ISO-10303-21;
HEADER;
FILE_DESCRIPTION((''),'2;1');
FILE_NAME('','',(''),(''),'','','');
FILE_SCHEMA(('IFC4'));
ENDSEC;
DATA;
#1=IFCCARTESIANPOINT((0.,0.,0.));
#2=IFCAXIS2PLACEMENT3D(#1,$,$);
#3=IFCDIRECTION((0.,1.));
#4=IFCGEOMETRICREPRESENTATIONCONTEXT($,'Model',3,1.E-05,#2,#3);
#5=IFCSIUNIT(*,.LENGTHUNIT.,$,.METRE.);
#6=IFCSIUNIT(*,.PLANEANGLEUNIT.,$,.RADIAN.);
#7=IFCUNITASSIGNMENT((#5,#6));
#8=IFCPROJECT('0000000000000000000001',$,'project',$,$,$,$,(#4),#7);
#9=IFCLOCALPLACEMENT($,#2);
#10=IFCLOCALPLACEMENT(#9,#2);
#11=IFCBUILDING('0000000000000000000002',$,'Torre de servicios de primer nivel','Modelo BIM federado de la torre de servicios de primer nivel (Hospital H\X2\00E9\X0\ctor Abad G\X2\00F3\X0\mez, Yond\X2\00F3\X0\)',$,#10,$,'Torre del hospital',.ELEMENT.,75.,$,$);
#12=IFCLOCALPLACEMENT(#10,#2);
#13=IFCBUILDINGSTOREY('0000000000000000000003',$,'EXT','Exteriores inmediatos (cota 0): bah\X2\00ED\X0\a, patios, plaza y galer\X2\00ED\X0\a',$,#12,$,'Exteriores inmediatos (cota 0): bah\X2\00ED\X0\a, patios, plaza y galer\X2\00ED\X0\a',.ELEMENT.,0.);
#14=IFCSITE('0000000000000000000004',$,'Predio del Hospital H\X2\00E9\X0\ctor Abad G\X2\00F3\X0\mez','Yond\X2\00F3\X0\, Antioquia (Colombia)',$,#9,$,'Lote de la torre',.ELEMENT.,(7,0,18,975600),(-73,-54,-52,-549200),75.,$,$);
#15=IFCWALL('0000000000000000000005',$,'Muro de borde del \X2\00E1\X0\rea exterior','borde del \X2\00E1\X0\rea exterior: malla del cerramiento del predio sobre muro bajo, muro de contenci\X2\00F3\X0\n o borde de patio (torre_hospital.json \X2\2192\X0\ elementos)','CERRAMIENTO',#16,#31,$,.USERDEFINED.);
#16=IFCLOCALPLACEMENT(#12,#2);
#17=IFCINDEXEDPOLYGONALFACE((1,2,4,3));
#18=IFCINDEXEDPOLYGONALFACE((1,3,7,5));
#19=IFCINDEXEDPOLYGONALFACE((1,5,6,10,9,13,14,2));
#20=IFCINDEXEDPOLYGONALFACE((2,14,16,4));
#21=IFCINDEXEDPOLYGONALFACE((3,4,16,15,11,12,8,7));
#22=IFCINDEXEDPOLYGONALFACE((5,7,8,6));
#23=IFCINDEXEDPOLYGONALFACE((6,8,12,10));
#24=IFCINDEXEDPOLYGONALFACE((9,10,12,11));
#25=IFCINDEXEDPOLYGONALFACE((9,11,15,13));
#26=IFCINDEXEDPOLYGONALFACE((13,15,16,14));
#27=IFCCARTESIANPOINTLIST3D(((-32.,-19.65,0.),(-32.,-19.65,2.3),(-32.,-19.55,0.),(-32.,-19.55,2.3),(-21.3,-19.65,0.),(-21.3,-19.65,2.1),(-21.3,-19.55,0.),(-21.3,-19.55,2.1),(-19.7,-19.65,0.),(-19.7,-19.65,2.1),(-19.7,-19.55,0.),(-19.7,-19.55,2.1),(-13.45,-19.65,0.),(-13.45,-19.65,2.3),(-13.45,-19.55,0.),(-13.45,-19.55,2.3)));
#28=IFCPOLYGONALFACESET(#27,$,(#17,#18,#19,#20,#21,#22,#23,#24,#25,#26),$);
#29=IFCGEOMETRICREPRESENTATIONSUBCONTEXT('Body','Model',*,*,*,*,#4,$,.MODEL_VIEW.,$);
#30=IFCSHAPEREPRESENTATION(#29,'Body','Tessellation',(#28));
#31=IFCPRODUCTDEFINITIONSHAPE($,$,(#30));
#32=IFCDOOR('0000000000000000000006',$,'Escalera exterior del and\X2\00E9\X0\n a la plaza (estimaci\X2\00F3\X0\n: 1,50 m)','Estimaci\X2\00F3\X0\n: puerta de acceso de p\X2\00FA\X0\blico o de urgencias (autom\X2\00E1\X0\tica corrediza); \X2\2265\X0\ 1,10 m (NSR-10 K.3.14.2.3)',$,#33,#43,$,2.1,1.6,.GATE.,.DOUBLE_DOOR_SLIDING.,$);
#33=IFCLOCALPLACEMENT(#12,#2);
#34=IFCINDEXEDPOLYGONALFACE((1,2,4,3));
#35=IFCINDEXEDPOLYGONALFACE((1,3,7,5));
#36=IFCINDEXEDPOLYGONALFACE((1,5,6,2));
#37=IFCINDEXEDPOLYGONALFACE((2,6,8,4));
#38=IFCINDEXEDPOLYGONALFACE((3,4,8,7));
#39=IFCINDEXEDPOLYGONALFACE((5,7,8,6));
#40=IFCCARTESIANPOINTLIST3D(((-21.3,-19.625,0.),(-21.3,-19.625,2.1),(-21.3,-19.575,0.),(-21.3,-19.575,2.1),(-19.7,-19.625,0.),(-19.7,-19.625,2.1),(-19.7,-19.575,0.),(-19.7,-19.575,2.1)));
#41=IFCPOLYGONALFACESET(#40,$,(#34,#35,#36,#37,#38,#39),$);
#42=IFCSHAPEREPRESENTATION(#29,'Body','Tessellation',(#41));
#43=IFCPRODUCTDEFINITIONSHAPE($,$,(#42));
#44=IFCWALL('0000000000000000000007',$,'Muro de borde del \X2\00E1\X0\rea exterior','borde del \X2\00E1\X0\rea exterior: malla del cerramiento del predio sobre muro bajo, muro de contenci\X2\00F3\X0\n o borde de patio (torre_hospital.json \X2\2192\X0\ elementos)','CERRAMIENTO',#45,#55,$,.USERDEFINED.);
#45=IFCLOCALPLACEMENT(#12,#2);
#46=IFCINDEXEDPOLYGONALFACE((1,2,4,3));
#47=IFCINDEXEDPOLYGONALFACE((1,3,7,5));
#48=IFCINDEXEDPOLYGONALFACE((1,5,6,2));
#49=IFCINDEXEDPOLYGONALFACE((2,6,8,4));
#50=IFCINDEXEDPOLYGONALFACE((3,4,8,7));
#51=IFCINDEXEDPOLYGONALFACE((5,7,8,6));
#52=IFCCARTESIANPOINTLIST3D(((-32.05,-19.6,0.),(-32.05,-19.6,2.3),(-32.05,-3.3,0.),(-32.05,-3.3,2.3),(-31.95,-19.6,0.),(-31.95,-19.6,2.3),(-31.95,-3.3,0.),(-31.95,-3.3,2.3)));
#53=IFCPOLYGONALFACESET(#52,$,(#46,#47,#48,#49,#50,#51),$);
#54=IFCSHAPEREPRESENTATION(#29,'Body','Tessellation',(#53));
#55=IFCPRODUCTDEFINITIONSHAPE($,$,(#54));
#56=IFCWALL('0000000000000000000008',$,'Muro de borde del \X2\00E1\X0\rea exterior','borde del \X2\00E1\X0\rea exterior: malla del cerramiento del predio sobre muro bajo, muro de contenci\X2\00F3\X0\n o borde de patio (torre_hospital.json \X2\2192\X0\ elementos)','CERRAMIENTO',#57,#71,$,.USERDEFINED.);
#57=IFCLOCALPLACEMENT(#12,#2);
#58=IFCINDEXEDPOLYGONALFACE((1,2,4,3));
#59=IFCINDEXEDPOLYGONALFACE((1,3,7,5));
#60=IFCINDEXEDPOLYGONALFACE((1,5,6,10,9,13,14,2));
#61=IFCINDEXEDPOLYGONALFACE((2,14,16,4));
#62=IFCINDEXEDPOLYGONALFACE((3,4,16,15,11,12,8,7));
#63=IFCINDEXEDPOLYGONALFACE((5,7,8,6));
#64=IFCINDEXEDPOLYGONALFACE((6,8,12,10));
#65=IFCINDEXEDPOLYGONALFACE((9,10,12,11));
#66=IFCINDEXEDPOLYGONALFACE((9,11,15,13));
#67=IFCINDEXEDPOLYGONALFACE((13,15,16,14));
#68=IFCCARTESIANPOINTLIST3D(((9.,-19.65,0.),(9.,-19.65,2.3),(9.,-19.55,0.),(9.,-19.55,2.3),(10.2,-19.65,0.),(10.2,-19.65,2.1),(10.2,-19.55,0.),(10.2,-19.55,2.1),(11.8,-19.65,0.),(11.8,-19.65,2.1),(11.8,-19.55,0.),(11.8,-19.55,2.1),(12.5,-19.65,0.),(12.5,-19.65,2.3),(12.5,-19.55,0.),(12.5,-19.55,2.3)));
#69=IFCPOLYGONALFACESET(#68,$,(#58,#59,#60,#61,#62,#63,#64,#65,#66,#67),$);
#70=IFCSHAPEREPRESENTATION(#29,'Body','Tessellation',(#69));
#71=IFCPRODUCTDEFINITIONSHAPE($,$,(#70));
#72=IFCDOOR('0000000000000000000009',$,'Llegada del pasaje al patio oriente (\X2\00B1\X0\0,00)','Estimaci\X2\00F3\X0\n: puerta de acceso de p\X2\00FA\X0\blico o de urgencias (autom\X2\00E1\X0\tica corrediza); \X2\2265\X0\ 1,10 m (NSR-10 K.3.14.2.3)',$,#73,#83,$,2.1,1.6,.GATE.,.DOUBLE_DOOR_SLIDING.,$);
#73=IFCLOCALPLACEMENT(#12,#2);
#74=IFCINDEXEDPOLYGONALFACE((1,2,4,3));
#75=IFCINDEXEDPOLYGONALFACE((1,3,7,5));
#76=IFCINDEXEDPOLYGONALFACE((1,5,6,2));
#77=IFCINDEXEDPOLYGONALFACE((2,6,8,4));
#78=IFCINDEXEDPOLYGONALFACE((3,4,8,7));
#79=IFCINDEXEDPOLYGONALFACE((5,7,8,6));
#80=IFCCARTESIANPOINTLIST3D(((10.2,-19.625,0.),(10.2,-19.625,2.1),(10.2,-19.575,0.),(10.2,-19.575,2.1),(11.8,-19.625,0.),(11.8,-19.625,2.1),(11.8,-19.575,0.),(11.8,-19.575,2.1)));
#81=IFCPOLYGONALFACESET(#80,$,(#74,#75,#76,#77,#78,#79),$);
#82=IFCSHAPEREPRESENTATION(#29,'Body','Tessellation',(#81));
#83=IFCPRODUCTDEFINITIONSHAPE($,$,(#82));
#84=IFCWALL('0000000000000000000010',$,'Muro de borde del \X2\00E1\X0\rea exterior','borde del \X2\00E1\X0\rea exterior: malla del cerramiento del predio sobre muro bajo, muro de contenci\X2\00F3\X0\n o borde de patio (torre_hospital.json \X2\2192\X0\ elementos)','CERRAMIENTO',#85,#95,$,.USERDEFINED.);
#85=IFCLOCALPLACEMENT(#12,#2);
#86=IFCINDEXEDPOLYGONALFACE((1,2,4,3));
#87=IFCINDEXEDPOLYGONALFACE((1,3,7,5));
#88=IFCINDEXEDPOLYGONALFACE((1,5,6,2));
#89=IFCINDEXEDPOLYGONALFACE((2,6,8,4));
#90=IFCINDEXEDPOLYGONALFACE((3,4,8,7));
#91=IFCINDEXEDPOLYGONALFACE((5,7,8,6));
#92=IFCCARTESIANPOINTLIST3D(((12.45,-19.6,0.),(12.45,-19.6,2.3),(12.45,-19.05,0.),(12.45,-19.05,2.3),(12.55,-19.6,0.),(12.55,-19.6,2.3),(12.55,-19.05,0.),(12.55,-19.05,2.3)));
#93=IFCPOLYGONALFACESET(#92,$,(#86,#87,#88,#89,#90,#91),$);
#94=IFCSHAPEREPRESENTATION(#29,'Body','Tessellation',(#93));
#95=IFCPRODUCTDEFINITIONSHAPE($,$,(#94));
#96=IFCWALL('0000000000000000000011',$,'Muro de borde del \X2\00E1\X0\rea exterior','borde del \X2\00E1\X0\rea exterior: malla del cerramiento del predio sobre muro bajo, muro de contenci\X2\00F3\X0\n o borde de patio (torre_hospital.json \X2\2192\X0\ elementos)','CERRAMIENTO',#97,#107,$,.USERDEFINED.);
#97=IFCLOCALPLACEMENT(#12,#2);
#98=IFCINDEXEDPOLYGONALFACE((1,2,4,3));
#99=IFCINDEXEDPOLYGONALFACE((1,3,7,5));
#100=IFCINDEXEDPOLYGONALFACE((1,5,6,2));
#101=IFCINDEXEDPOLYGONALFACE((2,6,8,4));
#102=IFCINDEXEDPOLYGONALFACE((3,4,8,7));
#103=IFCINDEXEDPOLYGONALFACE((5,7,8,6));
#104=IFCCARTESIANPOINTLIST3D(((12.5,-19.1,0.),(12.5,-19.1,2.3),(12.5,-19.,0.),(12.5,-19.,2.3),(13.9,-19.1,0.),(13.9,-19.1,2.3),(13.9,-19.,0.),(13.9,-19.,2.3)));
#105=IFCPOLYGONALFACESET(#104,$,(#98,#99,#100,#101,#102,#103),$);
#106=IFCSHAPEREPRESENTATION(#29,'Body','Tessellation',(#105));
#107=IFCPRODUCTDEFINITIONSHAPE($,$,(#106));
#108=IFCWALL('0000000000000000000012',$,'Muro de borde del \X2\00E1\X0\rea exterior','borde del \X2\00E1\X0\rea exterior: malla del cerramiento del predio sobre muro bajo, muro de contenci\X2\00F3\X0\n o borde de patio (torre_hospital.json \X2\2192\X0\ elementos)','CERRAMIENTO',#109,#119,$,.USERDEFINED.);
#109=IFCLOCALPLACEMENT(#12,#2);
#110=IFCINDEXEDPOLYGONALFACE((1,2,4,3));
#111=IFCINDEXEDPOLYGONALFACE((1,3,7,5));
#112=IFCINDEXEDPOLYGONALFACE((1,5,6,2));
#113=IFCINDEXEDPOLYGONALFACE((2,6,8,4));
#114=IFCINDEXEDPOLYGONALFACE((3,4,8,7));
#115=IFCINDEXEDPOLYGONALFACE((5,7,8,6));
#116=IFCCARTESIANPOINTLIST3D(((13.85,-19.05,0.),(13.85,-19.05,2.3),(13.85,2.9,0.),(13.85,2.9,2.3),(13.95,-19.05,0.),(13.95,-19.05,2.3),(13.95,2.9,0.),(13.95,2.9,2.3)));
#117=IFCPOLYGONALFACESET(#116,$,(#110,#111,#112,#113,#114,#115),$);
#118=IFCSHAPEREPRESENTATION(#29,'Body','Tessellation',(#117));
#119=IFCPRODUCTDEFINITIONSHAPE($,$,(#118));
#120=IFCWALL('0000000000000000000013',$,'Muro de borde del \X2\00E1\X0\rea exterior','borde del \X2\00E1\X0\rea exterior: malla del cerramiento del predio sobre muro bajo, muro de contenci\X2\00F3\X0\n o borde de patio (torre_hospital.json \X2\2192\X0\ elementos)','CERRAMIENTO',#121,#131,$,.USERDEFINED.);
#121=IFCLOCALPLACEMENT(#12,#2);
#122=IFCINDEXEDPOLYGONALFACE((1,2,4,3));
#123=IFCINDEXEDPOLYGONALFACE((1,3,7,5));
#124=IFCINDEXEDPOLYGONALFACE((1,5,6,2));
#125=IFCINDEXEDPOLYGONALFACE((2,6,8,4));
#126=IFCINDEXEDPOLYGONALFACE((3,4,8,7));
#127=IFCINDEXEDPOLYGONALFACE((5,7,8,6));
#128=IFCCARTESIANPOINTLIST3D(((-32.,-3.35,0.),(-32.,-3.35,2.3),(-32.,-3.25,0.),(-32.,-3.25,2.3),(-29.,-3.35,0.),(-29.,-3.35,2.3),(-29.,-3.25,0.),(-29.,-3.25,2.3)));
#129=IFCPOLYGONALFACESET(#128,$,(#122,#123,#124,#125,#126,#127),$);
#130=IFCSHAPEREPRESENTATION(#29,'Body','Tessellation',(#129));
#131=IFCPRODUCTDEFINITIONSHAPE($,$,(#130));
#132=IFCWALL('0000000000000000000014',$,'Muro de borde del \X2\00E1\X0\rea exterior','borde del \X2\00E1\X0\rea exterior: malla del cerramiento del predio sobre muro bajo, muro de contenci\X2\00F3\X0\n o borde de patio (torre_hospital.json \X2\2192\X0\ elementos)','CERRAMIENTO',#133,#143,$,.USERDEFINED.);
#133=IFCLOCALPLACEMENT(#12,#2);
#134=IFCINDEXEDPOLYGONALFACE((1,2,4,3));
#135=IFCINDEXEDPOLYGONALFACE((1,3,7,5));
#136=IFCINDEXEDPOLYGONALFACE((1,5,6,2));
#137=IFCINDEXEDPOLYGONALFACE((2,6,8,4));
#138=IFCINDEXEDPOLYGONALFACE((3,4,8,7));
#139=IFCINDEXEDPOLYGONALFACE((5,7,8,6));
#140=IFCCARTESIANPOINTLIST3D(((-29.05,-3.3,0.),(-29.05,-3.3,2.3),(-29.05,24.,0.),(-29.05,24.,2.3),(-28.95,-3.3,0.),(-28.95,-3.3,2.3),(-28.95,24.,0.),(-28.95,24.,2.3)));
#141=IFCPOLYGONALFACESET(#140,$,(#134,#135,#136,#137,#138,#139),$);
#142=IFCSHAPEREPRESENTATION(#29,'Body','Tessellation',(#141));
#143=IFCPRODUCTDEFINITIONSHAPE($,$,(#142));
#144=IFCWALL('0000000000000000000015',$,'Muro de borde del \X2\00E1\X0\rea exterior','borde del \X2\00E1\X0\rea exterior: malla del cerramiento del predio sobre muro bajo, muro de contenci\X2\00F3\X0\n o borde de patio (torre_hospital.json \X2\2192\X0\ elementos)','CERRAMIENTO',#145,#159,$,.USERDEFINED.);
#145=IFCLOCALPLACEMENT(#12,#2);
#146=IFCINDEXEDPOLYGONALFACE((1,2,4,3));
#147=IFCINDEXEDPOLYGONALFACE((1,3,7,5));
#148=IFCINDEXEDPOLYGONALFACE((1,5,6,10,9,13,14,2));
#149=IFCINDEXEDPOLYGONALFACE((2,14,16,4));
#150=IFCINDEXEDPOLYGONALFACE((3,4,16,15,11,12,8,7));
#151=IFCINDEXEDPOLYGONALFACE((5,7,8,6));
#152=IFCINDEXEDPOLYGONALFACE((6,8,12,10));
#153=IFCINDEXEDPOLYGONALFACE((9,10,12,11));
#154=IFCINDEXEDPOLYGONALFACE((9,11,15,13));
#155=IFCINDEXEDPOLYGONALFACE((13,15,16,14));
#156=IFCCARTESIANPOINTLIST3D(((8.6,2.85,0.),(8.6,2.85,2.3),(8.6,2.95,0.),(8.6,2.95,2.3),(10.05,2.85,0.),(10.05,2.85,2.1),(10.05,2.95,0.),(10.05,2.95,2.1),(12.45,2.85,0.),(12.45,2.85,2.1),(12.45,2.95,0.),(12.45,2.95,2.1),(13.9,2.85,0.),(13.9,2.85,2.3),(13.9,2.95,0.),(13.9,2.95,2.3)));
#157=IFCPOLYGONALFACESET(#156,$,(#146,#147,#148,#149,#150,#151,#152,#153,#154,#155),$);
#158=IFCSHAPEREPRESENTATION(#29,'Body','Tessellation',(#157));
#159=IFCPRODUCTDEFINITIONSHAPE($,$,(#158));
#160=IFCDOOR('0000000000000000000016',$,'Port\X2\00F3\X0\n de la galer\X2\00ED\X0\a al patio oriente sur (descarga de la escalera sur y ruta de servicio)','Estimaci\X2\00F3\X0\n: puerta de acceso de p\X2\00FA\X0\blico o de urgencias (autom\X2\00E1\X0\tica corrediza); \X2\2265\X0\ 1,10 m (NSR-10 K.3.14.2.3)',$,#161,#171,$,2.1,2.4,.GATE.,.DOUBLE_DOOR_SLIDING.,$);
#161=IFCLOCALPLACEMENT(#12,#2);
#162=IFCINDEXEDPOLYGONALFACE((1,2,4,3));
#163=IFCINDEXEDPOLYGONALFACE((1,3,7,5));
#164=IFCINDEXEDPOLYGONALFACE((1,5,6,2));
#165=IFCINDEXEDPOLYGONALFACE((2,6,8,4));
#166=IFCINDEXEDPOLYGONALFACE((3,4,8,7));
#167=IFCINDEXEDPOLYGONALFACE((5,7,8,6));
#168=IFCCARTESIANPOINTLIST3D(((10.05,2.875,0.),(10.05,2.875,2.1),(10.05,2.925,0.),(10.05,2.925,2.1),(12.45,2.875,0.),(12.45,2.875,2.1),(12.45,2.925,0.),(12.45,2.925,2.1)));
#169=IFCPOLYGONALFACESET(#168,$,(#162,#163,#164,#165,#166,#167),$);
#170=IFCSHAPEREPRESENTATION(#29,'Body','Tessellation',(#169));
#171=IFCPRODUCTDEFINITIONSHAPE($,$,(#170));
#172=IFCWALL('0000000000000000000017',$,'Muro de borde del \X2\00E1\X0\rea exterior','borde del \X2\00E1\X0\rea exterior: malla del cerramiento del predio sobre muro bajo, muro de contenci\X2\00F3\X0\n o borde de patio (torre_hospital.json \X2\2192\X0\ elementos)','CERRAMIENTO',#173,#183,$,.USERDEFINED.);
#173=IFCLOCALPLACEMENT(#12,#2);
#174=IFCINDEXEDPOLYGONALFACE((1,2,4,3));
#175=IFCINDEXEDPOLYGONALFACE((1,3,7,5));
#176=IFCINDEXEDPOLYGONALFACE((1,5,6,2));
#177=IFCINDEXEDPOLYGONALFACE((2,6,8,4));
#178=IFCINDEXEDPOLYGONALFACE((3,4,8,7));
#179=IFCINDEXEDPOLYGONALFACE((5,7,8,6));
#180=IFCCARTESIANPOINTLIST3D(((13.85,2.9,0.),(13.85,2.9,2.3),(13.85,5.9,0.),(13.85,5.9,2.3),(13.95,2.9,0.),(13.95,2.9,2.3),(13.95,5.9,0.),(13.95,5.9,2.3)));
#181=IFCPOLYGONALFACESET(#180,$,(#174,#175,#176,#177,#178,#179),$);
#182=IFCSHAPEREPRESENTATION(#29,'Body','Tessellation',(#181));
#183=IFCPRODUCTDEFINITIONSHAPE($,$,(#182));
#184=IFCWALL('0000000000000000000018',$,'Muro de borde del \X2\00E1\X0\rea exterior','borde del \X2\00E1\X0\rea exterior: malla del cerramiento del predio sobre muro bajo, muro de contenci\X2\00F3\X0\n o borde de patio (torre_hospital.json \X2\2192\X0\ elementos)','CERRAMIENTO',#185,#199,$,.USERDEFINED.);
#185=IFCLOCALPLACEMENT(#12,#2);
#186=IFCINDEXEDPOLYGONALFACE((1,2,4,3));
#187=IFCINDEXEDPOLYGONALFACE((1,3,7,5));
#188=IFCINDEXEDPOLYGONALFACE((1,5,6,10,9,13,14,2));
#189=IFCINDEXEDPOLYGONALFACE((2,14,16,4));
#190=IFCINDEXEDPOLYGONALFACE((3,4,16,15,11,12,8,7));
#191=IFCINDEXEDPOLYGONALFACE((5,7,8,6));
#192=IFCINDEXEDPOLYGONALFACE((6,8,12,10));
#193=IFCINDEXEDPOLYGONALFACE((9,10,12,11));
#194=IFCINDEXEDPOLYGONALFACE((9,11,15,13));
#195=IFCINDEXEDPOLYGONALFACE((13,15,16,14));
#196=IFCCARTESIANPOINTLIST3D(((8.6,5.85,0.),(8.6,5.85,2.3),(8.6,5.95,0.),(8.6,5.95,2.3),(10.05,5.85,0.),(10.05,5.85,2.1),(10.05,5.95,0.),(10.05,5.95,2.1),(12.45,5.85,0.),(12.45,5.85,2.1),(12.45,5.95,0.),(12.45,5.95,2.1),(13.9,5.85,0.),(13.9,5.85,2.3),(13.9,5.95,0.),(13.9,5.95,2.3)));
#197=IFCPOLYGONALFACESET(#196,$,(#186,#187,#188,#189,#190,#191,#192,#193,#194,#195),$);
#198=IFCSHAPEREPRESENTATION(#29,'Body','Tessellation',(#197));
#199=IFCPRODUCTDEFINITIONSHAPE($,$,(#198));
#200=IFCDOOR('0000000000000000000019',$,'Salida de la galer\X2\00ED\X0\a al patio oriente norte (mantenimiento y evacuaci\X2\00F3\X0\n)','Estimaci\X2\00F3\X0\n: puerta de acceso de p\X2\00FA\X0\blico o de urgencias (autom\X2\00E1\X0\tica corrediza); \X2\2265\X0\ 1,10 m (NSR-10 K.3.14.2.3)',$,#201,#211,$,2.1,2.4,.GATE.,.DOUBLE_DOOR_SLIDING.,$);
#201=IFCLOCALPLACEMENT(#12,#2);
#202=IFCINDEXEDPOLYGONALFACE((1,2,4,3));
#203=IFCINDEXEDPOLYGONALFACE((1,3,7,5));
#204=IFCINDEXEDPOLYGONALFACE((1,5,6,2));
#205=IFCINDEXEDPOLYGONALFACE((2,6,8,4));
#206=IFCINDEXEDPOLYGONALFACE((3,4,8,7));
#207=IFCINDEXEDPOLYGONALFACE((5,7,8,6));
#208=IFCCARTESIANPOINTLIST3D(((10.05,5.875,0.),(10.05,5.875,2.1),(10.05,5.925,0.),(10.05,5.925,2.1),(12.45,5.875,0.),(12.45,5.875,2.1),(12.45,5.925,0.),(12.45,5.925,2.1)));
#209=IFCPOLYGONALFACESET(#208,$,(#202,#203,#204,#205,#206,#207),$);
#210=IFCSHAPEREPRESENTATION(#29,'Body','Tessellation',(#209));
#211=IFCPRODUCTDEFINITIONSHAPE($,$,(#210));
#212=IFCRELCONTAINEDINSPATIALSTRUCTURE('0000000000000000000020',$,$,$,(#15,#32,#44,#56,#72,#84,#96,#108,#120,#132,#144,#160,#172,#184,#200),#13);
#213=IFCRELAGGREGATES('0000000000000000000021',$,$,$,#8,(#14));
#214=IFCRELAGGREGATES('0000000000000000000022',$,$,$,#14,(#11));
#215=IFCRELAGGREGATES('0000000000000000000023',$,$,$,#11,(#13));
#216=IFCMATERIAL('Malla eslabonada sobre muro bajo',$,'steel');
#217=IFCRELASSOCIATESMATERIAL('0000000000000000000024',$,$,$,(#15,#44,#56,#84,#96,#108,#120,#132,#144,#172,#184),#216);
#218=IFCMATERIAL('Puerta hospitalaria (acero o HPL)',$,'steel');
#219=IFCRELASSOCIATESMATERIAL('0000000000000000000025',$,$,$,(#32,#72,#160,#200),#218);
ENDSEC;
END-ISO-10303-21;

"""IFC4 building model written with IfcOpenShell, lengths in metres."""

from ifc_helpers import new_model, si_unit, direction, frame, origin, place, context, subcontext, project, spatial, rectangle, extrude, material, element, fill, save


model = new_model("IFC4")

# Units and contexts
model_context = context("Model", 3, precision=1e-05, world=origin(), true_north=direction((0.0, 1.0)))
body_context = subcontext(model_context, "Body", "Model", "MODEL_VIEW")
ifc_project = project(units=[si_unit("LENGTHUNIT", "METRE"), si_unit("PLANEANGLEUNIT", "RADIAN")], contexts=[model_context])

# Site, building, storey
site_placement = place(None, origin())
site = spatial("IfcSite", under=ifc_project, at=site_placement, Name="Predio del Hospital Héctor Abad Gómez", Description="Yondó, Antioquia (Colombia)", LongName="Lote de la torre", CompositionType="ELEMENT", RefLatitude=(7, 0, 18, 975600), RefLongitude=(-73, -54, -52, -549200), RefElevation=75.0)
building_placement = place(site_placement, origin())
building = spatial("IfcBuilding", under=site, at=building_placement, Name="Torre de servicios de primer nivel", Description="Modelo BIM federado de la torre de servicios de primer nivel (Hospital Héctor Abad Gómez, Yondó)", LongName="Torre del hospital", CompositionType="ELEMENT", ElevationOfRefHeight=75.0)
placement = place(building_placement, origin())
storey = spatial("IfcBuildingStorey", under=building, at=placement, Name="EXT", Description="Exteriores inmediatos (cota 0): bahía, patios, plaza y galería", LongName="Exteriores inmediatos (cota 0): bahía, patios, plaza y galería", CompositionType="ELEMENT", Elevation=0.0)

# Wall, opening, door
ifc_material_1 = material(Name="Malla eslabonada sobre muro bajo", Category="steel")
wall_1 = element("IfcWall", 1, at=placement, inside=storey, material=ifc_material_1, Name="Muro de borde del área exterior", Description="borde del área exterior: malla del cerramiento del predio sobre muro bajo, muro de contención o borde de patio (torre_hospital.json → elementos)", ObjectType="CERRAMIENTO", PredefinedType="USERDEFINED", context=body_context, shape_type="SweptSolid", body=[
    extrude(rectangle(XDim=18.55, YDim=0.1), frame((-22.725, -19.6, 0.0)), (0.0, 0.0, 1.0), 2.3),
])
opening_1 = element("IfcOpeningElement", 2, at=placement, cuts=wall_1, PredefinedType="OPENING", context=body_context, shape_type="SweptSolid", body=[
    extrude(rectangle(XDim=1.6, YDim=0.2), frame((-20.5, -19.6, 0.0)), (0.0, 0.0, 1.0), 2.1),
])
ifc_material_2 = material(Name="Puerta hospitalaria (acero o HPL)", Category="steel")
door_1 = element("IfcDoor", 3, at=placement, inside=storey, material=ifc_material_2, Name="Escalera exterior del andén a la plaza (estimación: 1,50 m)", Description="Estimación: puerta de acceso de público o de urgencias (automática corrediza); ≥ 1,10 m (NSR-10 K.3.14.2.3)", OperationType="DOUBLE_DOOR_SLIDING", OverallHeight=2.1, OverallWidth=1.6, PredefinedType="GATE", context=body_context, shape_type="SweptSolid", body=[
    extrude(rectangle(XDim=1.6, YDim=0.05), frame((-20.5, -19.6, 0.0)), (0.0, 0.0, 1.0), 2.1),
])
fill(opening_1, door_1)

# Wall
element("IfcWall", 4, at=placement, inside=storey, material=ifc_material_1, Name="Muro de borde del área exterior", Description="borde del área exterior: malla del cerramiento del predio sobre muro bajo, muro de contención o borde de patio (torre_hospital.json → elementos)", ObjectType="CERRAMIENTO", PredefinedType="USERDEFINED", context=body_context, shape_type="SweptSolid", body=[
    extrude(rectangle(XDim=0.1, YDim=16.3), frame((-32.0, -11.45, 0.0)), (0.0, 0.0, 1.0), 2.3),
])

# Wall, opening, door
wall_2 = element("IfcWall", 5, at=placement, inside=storey, material=ifc_material_1, Name="Muro de borde del área exterior", Description="borde del área exterior: malla del cerramiento del predio sobre muro bajo, muro de contención o borde de patio (torre_hospital.json → elementos)", ObjectType="CERRAMIENTO", PredefinedType="USERDEFINED", context=body_context, shape_type="SweptSolid", body=[
    extrude(rectangle(XDim=3.5, YDim=0.1), frame((10.75, -19.6, 0.0)), (0.0, 0.0, 1.0), 2.3),
])
opening_2 = element("IfcOpeningElement", 6, at=placement, cuts=wall_2, PredefinedType="OPENING", context=body_context, shape_type="SweptSolid", body=[
    extrude(rectangle(XDim=1.6, YDim=0.2), frame((11.0, -19.6, 0.0)), (0.0, 0.0, 1.0), 2.1),
])
door_2 = element("IfcDoor", 7, at=placement, inside=storey, material=ifc_material_2, Name="Llegada del pasaje al patio oriente (±0,00)", Description="Estimación: puerta de acceso de público o de urgencias (automática corrediza); ≥ 1,10 m (NSR-10 K.3.14.2.3)", OperationType="DOUBLE_DOOR_SLIDING", OverallHeight=2.1, OverallWidth=1.6, PredefinedType="GATE", context=body_context, shape_type="SweptSolid", body=[
    extrude(rectangle(XDim=1.6, YDim=0.05), frame((11.0, -19.6, 0.0)), (0.0, 0.0, 1.0), 2.1),
])
fill(opening_2, door_2)

# Walls
element("IfcWall", 8, at=placement, inside=storey, material=ifc_material_1, Name="Muro de borde del área exterior", Description="borde del área exterior: malla del cerramiento del predio sobre muro bajo, muro de contención o borde de patio (torre_hospital.json → elementos)", ObjectType="CERRAMIENTO", PredefinedType="USERDEFINED", context=body_context, shape_type="SweptSolid", body=[
    extrude(rectangle(XDim=0.1, YDim=0.55), frame((12.5, -19.325, 0.0)), (0.0, 0.0, 1.0), 2.3),
])
element("IfcWall", 9, at=placement, inside=storey, material=ifc_material_1, Name="Muro de borde del área exterior", Description="borde del área exterior: malla del cerramiento del predio sobre muro bajo, muro de contención o borde de patio (torre_hospital.json → elementos)", ObjectType="CERRAMIENTO", PredefinedType="USERDEFINED", context=body_context, shape_type="SweptSolid", body=[
    extrude(rectangle(XDim=1.4, YDim=0.1), frame((13.2, -19.05, 0.0)), (0.0, 0.0, 1.0), 2.3),
])
element("IfcWall", 10, at=placement, inside=storey, material=ifc_material_1, Name="Muro de borde del área exterior", Description="borde del área exterior: malla del cerramiento del predio sobre muro bajo, muro de contención o borde de patio (torre_hospital.json → elementos)", ObjectType="CERRAMIENTO", PredefinedType="USERDEFINED", context=body_context, shape_type="SweptSolid", body=[
    extrude(rectangle(XDim=0.1, YDim=21.95), frame((13.9, -8.075, 0.0)), (0.0, 0.0, 1.0), 2.3),
])
element("IfcWall", 11, at=placement, inside=storey, material=ifc_material_1, Name="Muro de borde del área exterior", Description="borde del área exterior: malla del cerramiento del predio sobre muro bajo, muro de contención o borde de patio (torre_hospital.json → elementos)", ObjectType="CERRAMIENTO", PredefinedType="USERDEFINED", context=body_context, shape_type="SweptSolid", body=[
    extrude(rectangle(XDim=3.0, YDim=0.1), frame((-30.5, -3.3, 0.0)), (0.0, 0.0, 1.0), 2.3),
])
element("IfcWall", 12, at=placement, inside=storey, material=ifc_material_1, Name="Muro de borde del área exterior", Description="borde del área exterior: malla del cerramiento del predio sobre muro bajo, muro de contención o borde de patio (torre_hospital.json → elementos)", ObjectType="CERRAMIENTO", PredefinedType="USERDEFINED", context=body_context, shape_type="SweptSolid", body=[
    extrude(rectangle(XDim=0.1, YDim=27.3), frame((-29.0, 10.35, 0.0)), (0.0, 0.0, 1.0), 2.3),
])

# Wall, opening, door
wall_3 = element("IfcWall", 13, at=placement, inside=storey, material=ifc_material_1, Name="Muro de borde del área exterior", Description="borde del área exterior: malla del cerramiento del predio sobre muro bajo, muro de contención o borde de patio (torre_hospital.json → elementos)", ObjectType="CERRAMIENTO", PredefinedType="USERDEFINED", context=body_context, shape_type="SweptSolid", body=[
    extrude(rectangle(XDim=5.3, YDim=0.1), frame((11.25, 2.9, 0.0)), (0.0, 0.0, 1.0), 2.3),
])
opening_3 = element("IfcOpeningElement", 14, at=placement, cuts=wall_3, PredefinedType="OPENING", context=body_context, shape_type="SweptSolid", body=[
    extrude(rectangle(XDim=2.4, YDim=0.2), frame((11.25, 2.9, 0.0)), (0.0, 0.0, 1.0), 2.1),
])
door_3 = element("IfcDoor", 15, at=placement, inside=storey, material=ifc_material_2, Name="Portón de la galería al patio oriente sur (descarga de la escalera sur y ruta de servicio)", Description="Estimación: puerta de acceso de público o de urgencias (automática corrediza); ≥ 1,10 m (NSR-10 K.3.14.2.3)", OperationType="DOUBLE_DOOR_SLIDING", OverallHeight=2.1, OverallWidth=2.4, PredefinedType="GATE", context=body_context, shape_type="SweptSolid", body=[
    extrude(rectangle(XDim=2.4, YDim=0.05), frame((11.25, 2.9, 0.0)), (0.0, 0.0, 1.0), 2.1),
])
fill(opening_3, door_3)

# Wall
element("IfcWall", 16, at=placement, inside=storey, material=ifc_material_1, Name="Muro de borde del área exterior", Description="borde del área exterior: malla del cerramiento del predio sobre muro bajo, muro de contención o borde de patio (torre_hospital.json → elementos)", ObjectType="CERRAMIENTO", PredefinedType="USERDEFINED", context=body_context, shape_type="SweptSolid", body=[
    extrude(rectangle(XDim=0.1, YDim=3.0), frame((13.9, 4.4, 0.0)), (0.0, 0.0, 1.0), 2.3),
])

# Wall, opening, door
wall_4 = element("IfcWall", 17, at=placement, inside=storey, material=ifc_material_1, Name="Muro de borde del área exterior", Description="borde del área exterior: malla del cerramiento del predio sobre muro bajo, muro de contención o borde de patio (torre_hospital.json → elementos)", ObjectType="CERRAMIENTO", PredefinedType="USERDEFINED", context=body_context, shape_type="SweptSolid", body=[
    extrude(rectangle(XDim=5.3, YDim=0.1), frame((11.25, 5.9, 0.0)), (0.0, 0.0, 1.0), 2.3),
])
opening_4 = element("IfcOpeningElement", 18, at=placement, cuts=wall_4, PredefinedType="OPENING", context=body_context, shape_type="SweptSolid", body=[
    extrude(rectangle(XDim=2.4, YDim=0.2), frame((11.25, 5.9, 0.0)), (0.0, 0.0, 1.0), 2.1),
])
door_4 = element("IfcDoor", 19, at=placement, inside=storey, material=ifc_material_2, Name="Salida de la galería al patio oriente norte (mantenimiento y evacuación)", Description="Estimación: puerta de acceso de público o de urgencias (automática corrediza); ≥ 1,10 m (NSR-10 K.3.14.2.3)", OperationType="DOUBLE_DOOR_SLIDING", OverallHeight=2.1, OverallWidth=2.4, PredefinedType="GATE", context=body_context, shape_type="SweptSolid", body=[
    extrude(rectangle(XDim=2.4, YDim=0.05), frame((11.25, 5.9, 0.0)), (0.0, 0.0, 1.0), 2.1),
])
fill(opening_4, door_4)

save(model, "model.ifc")
